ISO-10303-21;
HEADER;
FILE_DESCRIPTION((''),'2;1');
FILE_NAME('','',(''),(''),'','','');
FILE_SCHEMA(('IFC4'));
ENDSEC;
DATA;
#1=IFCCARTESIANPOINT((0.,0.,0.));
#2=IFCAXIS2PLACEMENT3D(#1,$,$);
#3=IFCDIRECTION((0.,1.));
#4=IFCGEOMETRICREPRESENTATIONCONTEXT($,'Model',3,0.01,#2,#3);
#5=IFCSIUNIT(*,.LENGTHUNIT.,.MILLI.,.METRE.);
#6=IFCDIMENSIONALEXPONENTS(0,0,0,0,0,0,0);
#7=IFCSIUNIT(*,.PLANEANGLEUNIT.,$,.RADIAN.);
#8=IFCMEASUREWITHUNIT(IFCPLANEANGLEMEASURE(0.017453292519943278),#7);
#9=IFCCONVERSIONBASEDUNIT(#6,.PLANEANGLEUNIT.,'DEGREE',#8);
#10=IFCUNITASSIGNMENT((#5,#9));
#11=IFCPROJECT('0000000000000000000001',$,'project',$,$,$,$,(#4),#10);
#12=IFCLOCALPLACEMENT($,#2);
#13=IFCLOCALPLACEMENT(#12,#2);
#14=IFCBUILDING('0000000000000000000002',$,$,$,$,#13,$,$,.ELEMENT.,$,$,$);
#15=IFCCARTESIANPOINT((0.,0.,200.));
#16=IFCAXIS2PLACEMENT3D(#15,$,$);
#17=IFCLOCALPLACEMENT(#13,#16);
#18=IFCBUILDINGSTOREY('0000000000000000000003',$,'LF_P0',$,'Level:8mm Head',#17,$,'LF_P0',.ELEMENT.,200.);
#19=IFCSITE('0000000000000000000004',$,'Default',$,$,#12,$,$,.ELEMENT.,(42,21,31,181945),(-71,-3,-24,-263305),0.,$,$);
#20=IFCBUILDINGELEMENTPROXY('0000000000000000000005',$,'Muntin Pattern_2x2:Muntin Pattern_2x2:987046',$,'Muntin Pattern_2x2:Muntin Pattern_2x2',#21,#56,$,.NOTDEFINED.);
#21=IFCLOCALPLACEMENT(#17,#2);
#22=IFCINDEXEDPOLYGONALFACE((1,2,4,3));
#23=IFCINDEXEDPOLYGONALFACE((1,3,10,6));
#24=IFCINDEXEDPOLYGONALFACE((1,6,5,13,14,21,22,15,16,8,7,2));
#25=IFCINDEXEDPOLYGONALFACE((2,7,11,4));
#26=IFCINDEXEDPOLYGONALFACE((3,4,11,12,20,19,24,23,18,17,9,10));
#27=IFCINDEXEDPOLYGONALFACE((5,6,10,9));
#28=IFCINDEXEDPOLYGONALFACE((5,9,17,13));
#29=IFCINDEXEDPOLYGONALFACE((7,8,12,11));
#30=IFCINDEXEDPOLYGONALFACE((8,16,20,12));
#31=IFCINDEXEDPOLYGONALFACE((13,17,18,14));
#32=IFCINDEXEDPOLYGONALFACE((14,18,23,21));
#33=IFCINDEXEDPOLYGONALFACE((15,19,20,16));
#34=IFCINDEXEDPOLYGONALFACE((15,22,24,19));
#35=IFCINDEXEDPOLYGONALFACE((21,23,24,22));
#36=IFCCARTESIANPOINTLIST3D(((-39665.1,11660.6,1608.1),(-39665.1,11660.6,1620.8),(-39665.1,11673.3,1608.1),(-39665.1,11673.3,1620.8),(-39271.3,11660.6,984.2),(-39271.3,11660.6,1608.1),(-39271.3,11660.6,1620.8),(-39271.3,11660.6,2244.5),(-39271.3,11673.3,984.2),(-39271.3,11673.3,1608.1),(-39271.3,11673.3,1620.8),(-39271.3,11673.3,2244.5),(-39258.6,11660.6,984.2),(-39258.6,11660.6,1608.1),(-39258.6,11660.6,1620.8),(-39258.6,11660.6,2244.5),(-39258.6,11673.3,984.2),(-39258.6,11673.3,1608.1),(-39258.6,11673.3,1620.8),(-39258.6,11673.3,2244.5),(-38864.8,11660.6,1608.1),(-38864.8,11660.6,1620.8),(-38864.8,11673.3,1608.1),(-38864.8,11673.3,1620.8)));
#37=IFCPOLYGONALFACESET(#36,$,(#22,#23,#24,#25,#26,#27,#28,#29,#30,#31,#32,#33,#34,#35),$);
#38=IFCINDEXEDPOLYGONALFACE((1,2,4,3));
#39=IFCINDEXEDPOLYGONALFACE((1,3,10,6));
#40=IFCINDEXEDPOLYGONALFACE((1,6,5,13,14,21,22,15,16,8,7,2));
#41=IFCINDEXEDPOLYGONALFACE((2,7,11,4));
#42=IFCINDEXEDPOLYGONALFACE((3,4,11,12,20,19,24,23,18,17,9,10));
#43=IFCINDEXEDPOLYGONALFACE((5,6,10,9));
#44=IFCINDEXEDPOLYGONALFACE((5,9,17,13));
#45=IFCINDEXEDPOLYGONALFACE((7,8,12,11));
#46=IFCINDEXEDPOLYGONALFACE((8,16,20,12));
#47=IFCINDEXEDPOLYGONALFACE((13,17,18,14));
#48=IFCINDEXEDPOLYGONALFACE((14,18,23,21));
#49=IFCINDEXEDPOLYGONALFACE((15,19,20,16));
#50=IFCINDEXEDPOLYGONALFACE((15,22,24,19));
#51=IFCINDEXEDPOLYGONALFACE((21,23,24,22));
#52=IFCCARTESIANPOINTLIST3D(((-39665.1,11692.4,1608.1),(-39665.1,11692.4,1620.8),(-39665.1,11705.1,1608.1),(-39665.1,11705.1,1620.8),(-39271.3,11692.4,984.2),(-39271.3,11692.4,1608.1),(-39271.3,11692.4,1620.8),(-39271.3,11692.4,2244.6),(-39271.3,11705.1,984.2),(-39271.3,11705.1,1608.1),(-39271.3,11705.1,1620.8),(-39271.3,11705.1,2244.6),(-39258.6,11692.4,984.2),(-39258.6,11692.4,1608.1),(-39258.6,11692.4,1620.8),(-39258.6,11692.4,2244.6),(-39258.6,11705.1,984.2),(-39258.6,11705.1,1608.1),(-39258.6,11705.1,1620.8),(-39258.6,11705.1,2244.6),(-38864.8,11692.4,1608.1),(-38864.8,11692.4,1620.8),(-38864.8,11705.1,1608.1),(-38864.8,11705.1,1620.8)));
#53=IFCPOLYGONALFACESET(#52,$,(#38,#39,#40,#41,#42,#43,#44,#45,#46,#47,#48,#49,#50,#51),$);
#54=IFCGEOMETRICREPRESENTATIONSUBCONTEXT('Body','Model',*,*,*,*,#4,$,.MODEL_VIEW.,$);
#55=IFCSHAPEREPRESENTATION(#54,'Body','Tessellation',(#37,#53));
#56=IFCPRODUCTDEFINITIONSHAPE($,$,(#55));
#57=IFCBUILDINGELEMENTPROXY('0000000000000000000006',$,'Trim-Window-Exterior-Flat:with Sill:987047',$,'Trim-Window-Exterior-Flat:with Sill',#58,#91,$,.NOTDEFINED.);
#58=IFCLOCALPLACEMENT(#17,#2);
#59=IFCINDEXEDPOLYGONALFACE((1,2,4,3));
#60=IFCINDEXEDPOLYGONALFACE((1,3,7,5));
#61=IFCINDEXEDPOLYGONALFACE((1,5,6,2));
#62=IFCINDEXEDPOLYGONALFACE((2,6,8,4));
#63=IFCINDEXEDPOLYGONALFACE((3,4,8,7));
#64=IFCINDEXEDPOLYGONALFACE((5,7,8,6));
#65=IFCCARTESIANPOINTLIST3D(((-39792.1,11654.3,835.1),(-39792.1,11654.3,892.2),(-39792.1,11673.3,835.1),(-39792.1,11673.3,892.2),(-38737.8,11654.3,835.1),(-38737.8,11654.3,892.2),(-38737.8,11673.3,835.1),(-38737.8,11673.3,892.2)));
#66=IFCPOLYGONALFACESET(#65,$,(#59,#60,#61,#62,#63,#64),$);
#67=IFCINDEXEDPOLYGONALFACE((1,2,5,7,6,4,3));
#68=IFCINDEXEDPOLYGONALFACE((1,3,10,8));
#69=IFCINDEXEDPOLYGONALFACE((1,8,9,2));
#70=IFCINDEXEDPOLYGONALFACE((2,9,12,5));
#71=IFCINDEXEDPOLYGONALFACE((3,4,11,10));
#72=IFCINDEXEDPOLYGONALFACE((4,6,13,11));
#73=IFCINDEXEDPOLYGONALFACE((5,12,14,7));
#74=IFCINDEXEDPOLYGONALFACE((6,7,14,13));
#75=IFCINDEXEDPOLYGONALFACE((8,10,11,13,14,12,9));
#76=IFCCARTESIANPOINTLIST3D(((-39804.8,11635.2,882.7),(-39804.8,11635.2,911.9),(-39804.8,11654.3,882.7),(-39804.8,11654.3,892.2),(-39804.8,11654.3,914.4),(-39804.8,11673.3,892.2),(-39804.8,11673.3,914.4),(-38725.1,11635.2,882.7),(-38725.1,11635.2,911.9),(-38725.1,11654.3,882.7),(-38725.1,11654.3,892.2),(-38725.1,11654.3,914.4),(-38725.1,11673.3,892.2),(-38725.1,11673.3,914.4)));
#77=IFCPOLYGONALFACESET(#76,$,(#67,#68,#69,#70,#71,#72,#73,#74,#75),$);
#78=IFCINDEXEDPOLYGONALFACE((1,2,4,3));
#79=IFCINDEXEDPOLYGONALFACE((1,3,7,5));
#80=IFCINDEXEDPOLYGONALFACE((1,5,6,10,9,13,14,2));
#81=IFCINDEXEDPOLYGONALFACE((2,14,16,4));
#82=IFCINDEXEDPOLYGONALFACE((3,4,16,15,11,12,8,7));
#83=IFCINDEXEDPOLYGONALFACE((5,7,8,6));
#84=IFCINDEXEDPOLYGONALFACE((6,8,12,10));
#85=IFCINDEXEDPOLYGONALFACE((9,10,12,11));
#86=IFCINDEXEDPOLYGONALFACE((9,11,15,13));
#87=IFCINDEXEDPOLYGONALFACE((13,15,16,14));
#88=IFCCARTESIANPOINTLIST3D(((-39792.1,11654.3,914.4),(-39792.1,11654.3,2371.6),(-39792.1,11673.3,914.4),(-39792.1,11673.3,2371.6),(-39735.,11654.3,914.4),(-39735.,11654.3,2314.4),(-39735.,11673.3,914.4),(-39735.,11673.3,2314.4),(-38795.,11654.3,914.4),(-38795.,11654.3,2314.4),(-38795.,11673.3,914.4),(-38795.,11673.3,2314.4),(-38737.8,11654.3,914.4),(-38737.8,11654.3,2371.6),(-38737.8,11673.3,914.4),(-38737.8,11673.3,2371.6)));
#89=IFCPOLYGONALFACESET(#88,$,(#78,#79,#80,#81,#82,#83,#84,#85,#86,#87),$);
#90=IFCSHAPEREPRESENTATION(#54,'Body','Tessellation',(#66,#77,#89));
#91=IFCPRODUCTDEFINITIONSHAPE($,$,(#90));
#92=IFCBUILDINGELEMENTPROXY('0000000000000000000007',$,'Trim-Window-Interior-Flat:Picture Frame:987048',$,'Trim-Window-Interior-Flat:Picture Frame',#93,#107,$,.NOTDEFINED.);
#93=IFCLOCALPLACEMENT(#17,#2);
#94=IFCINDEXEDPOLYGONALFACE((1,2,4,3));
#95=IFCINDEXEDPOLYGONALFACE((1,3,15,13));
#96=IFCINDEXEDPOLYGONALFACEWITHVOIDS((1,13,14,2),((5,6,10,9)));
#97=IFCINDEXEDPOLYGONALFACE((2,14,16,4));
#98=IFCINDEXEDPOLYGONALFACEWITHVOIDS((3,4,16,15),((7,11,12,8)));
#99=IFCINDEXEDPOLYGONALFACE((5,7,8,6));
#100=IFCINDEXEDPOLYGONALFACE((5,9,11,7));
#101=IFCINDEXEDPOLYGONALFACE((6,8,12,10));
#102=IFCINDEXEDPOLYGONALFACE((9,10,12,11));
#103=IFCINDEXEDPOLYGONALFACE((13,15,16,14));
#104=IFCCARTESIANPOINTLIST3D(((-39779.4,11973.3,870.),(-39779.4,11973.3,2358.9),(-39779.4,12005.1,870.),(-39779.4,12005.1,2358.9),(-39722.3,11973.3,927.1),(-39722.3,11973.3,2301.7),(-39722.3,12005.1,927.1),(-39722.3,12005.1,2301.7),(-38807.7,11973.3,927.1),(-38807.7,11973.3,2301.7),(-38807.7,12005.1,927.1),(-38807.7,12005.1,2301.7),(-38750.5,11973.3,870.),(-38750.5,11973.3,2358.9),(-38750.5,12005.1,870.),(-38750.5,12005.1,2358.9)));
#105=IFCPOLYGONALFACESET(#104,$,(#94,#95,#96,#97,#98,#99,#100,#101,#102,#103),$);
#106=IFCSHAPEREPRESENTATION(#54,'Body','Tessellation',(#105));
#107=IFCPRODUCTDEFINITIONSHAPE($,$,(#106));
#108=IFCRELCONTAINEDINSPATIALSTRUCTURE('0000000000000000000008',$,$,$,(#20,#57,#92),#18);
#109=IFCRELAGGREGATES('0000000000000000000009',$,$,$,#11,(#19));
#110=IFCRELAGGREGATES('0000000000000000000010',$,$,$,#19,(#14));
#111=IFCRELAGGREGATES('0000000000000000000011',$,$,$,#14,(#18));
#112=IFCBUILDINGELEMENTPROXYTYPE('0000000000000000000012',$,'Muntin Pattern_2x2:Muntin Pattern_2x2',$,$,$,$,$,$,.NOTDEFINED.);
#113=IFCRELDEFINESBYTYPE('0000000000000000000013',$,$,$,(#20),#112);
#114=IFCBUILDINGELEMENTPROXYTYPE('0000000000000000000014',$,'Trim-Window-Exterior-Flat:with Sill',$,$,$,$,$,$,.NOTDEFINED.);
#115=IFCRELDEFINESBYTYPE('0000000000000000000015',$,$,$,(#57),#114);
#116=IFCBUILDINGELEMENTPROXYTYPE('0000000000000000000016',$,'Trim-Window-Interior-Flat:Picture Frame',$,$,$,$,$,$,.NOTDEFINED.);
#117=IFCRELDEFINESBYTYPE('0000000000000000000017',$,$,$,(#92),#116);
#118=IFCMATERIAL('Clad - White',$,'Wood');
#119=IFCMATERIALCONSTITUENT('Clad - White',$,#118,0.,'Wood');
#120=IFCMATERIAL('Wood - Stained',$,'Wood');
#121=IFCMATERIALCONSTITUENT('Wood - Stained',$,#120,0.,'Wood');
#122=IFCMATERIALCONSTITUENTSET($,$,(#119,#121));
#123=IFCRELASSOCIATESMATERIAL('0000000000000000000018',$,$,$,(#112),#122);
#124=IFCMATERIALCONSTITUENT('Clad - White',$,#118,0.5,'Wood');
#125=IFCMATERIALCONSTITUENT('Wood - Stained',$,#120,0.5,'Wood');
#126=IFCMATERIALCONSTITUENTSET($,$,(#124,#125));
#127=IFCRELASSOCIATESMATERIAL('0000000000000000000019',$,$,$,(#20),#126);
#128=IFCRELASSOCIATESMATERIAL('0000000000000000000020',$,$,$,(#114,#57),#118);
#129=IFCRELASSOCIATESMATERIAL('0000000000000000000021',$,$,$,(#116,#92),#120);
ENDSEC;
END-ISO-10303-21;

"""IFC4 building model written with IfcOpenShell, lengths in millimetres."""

from ifc_helpers import new_model, entity, si_unit, converted_unit, direction, frame, origin, place, context, subcontext, project, spatial, indexed_curve, outline, extrude, source, transform, mapped, material, constituent, constituent_set, type_object, type_shapes, element, save


model = new_model("IFC4")

# Units and contexts
model_context = context("Model", 3, precision=0.01, world=origin(), true_north=direction((0.0, 1.0)))
body_context = subcontext(model_context, "Body", "Model", "MODEL_VIEW")
ifc_project = project(units=[si_unit("LENGTHUNIT", "METRE", prefix="MILLI"), converted_unit("PLANEANGLEUNIT", "DEGREE", entity("IfcPlaneAngleMeasure", 0.017453292519943278), si_unit("PLANEANGLEUNIT", "RADIAN"), dimensions=[0, 0, 0, 0, 0, 0, 0])], contexts=[model_context])

# Site, building, storey
site_placement = place(None, origin())
site = spatial("IfcSite", under=ifc_project, at=site_placement, Name="Default", CompositionType="ELEMENT", RefLatitude=(42, 21, 31, 181945), RefLongitude=(-71, -3, -24, -263305), RefElevation=0.0)
building_placement = place(site_placement, origin())
building = spatial("IfcBuilding", under=site, at=building_placement, CompositionType="ELEMENT")
storey_placement = place(building_placement, frame((0.0, 0.0, 200.0)))
storey = spatial("IfcBuildingStorey", under=building, at=storey_placement, Name="LF_P0", ObjectType="Level:8mm Head", LongName="LF_P0", CompositionType="ELEMENT", Elevation=200.0)

# Building element proxies
ifc_material_1 = material(Name="Clad - White", Category="Wood")
ifc_material_2 = material(Name="Wood - Stained", Category="Wood")
ifc_constituent_1 = constituent(ifc_material_1, Name="Clad - White", Category="Wood", fraction=0.5)
ifc_constituent_2 = constituent(ifc_material_2, Name="Wood - Stained", Category="Wood", fraction=0.5)
ifc_constituent_set_1 = constituent_set(constituents=[ifc_constituent_1, ifc_constituent_2])
ifc_constituent_3 = constituent(ifc_material_1, Name="Clad - White", Category="Wood", fraction=0.0)
ifc_constituent_4 = constituent(ifc_material_2, Name="Wood - Stained", Category="Wood", fraction=0.0)
ifc_constituent_set_2 = constituent_set(constituents=[ifc_constituent_3, ifc_constituent_4])
building_element_proxy_type_1 = type_object("IfcBuildingElementProxyType", Name="Muntin Pattern_2x2:Muntin Pattern_2x2", PredefinedType="NOTDEFINED", material=ifc_constituent_set_2)
shared_shape_1 = source(origin(), body_context, "Body", "SweptSolid", [
    extrude(outline(indexed_curve([(6.4, -6.4), (630.1, -6.4), (630.1, 6.3), (6.4, 6.3), (6.4, 400.2), (-6.3, 400.2), (-6.3, 6.3), (-630.2, 6.3), (-630.2, -6.4), (-6.3, -6.4), (-6.3, -400.1), (6.4, -400.1), (6.4, -6.4)], self_intersect=False)), frame((0.0, -22.2, 630.1), z_axis=(0.0, 1.0, 0.0), x_axis=(0.0, 0.0, 1.0)), (0.0, 0.0, 1.0), 12.7),
    extrude(outline(indexed_curve([(6.4, -6.4), (630.2, -6.4), (630.2, 6.3), (6.4, 6.3), (6.4, 400.2), (-6.3, 400.2), (-6.3, 6.3), (-630.2, 6.3), (-630.2, -6.4), (-6.3, -6.4), (-6.3, -400.1), (6.4, -400.1), (6.4, -6.4)], self_intersect=False)), frame((0.0, 9.5, 630.2), z_axis=(0.0, 1.0, 0.0), x_axis=(0.0, 0.0, 1.0)), (0.0, 0.0, 1.0), 12.7),
])
type_shapes(building_element_proxy_type_1, [shared_shape_1])
proxy_1_placement = place(storey_placement, frame((-39265.0, 11682.9, 984.3)))
element("IfcBuildingElementProxy", 1, at=proxy_1_placement, inside=storey, type_object=building_element_proxy_type_1, material=ifc_constituent_set_1, Name="Muntin Pattern_2x2:Muntin Pattern_2x2:987046", ObjectType="Muntin Pattern_2x2:Muntin Pattern_2x2", PredefinedType="NOTDEFINED", context=body_context, shape_type="MappedRepresentation", body=[
    mapped(shared_shape_1, transform((0.0, 0.0, 0.0), scale=1.0)),
])
building_element_proxy_type_2 = type_object("IfcBuildingElementProxyType", Name="Trim-Window-Exterior-Flat:with Sill", PredefinedType="NOTDEFINED", material=ifc_material_1)
shared_shape_2 = source(origin(), body_context, "Body", "SweptSolid", [
    extrude(outline(indexed_curve([(-28.6, -527.1), (28.6, -527.1), (28.6, 527.1), (-28.6, 527.1), (-28.6, -527.1)], self_intersect=False)), frame((0.0, 1450.8, 0.0), z_axis=(0.0, 0.0, 1.0), x_axis=(0.0, 1.0, 0.0)), (0.0, 0.0, 1.0), 19.0),
    extrude(outline(indexed_curve([(-16.0, -19.0), (13.3, -19.0), (15.8, 0.0), (15.8, 19.0), (-6.4, 19.0), (-6.4, 0.0), (-16.0, 0.0), (-16.0, -19.0)], self_intersect=False)), frame((-539.8, 1415.8, 19.0), z_axis=(1.0, 0.0, 0.0), x_axis=(0.0, -1.0, 0.0)), (0.0, 0.0, 1.0), 1079.7),
    extrude(outline(indexed_curve([(-527.1, -742.9), (527.1, -742.9), (527.1, 714.3), (470.0, 714.3), (470.0, -685.7), (-470.0, -685.7), (-470.0, 714.3), (-527.1, 714.3), (-527.1, -742.9)], self_intersect=False)), frame((0.0, 685.7, 0.0)), (0.0, 0.0, 1.0), 19.0),
])
type_shapes(building_element_proxy_type_2, [shared_shape_2])
proxy_2_placement = place(storey_placement, frame((-39265.0, 11673.3, 2314.4), z_axis=(0.0, -1.0, 0.0), x_axis=(-1.0, 0.0, 0.0)))
element("IfcBuildingElementProxy", 2, at=proxy_2_placement, inside=storey, type_object=building_element_proxy_type_2, material=ifc_material_1, Name="Trim-Window-Exterior-Flat:with Sill:987047", ObjectType="Trim-Window-Exterior-Flat:with Sill", PredefinedType="NOTDEFINED", context=body_context, shape_type="MappedRepresentation", body=[
    mapped(shared_shape_2, transform((0.0, 0.0, 0.0), scale=1.0)),
])
building_element_proxy_type_3 = type_object("IfcBuildingElementProxyType", Name="Trim-Window-Interior-Flat:Picture Frame", PredefinedType="NOTDEFINED", material=ifc_material_2)
shared_shape_3 = source(origin(), body_context, "Body", "SweptSolid", [
    extrude(outline(indexed_curve([(-744.4, -514.4), (744.4, -514.4), (744.4, 514.4), (-744.4, 514.4), (-744.4, -514.4)], self_intersect=False), holes=[indexed_curve([(-687.3, -457.3), (-687.3, 457.3), (687.3, 457.3), (687.3, -457.3), (-687.3, -457.3)], self_intersect=False)]), frame((0.0, 700.0, 0.0), z_axis=(0.0, 0.0, 1.0), x_axis=(0.0, 1.0, 0.0)), (0.0, 0.0, 1.0), 31.7),
])
type_shapes(building_element_proxy_type_3, [shared_shape_3])
proxy_3_placement = place(storey_placement, frame((-39265.0, 11973.3, 2314.4), z_axis=(0.0, 1.0, 0.0), x_axis=(1.0, 0.0, 0.0)))
element("IfcBuildingElementProxy", 3, at=proxy_3_placement, inside=storey, type_object=building_element_proxy_type_3, material=ifc_material_2, Name="Trim-Window-Interior-Flat:Picture Frame:987048", ObjectType="Trim-Window-Interior-Flat:Picture Frame", PredefinedType="NOTDEFINED", context=body_context, shape_type="MappedRepresentation", body=[
    mapped(shared_shape_3, transform((0.0, 0.0, 0.0), scale=1.0)),
])

save(model, "model.ifc")
